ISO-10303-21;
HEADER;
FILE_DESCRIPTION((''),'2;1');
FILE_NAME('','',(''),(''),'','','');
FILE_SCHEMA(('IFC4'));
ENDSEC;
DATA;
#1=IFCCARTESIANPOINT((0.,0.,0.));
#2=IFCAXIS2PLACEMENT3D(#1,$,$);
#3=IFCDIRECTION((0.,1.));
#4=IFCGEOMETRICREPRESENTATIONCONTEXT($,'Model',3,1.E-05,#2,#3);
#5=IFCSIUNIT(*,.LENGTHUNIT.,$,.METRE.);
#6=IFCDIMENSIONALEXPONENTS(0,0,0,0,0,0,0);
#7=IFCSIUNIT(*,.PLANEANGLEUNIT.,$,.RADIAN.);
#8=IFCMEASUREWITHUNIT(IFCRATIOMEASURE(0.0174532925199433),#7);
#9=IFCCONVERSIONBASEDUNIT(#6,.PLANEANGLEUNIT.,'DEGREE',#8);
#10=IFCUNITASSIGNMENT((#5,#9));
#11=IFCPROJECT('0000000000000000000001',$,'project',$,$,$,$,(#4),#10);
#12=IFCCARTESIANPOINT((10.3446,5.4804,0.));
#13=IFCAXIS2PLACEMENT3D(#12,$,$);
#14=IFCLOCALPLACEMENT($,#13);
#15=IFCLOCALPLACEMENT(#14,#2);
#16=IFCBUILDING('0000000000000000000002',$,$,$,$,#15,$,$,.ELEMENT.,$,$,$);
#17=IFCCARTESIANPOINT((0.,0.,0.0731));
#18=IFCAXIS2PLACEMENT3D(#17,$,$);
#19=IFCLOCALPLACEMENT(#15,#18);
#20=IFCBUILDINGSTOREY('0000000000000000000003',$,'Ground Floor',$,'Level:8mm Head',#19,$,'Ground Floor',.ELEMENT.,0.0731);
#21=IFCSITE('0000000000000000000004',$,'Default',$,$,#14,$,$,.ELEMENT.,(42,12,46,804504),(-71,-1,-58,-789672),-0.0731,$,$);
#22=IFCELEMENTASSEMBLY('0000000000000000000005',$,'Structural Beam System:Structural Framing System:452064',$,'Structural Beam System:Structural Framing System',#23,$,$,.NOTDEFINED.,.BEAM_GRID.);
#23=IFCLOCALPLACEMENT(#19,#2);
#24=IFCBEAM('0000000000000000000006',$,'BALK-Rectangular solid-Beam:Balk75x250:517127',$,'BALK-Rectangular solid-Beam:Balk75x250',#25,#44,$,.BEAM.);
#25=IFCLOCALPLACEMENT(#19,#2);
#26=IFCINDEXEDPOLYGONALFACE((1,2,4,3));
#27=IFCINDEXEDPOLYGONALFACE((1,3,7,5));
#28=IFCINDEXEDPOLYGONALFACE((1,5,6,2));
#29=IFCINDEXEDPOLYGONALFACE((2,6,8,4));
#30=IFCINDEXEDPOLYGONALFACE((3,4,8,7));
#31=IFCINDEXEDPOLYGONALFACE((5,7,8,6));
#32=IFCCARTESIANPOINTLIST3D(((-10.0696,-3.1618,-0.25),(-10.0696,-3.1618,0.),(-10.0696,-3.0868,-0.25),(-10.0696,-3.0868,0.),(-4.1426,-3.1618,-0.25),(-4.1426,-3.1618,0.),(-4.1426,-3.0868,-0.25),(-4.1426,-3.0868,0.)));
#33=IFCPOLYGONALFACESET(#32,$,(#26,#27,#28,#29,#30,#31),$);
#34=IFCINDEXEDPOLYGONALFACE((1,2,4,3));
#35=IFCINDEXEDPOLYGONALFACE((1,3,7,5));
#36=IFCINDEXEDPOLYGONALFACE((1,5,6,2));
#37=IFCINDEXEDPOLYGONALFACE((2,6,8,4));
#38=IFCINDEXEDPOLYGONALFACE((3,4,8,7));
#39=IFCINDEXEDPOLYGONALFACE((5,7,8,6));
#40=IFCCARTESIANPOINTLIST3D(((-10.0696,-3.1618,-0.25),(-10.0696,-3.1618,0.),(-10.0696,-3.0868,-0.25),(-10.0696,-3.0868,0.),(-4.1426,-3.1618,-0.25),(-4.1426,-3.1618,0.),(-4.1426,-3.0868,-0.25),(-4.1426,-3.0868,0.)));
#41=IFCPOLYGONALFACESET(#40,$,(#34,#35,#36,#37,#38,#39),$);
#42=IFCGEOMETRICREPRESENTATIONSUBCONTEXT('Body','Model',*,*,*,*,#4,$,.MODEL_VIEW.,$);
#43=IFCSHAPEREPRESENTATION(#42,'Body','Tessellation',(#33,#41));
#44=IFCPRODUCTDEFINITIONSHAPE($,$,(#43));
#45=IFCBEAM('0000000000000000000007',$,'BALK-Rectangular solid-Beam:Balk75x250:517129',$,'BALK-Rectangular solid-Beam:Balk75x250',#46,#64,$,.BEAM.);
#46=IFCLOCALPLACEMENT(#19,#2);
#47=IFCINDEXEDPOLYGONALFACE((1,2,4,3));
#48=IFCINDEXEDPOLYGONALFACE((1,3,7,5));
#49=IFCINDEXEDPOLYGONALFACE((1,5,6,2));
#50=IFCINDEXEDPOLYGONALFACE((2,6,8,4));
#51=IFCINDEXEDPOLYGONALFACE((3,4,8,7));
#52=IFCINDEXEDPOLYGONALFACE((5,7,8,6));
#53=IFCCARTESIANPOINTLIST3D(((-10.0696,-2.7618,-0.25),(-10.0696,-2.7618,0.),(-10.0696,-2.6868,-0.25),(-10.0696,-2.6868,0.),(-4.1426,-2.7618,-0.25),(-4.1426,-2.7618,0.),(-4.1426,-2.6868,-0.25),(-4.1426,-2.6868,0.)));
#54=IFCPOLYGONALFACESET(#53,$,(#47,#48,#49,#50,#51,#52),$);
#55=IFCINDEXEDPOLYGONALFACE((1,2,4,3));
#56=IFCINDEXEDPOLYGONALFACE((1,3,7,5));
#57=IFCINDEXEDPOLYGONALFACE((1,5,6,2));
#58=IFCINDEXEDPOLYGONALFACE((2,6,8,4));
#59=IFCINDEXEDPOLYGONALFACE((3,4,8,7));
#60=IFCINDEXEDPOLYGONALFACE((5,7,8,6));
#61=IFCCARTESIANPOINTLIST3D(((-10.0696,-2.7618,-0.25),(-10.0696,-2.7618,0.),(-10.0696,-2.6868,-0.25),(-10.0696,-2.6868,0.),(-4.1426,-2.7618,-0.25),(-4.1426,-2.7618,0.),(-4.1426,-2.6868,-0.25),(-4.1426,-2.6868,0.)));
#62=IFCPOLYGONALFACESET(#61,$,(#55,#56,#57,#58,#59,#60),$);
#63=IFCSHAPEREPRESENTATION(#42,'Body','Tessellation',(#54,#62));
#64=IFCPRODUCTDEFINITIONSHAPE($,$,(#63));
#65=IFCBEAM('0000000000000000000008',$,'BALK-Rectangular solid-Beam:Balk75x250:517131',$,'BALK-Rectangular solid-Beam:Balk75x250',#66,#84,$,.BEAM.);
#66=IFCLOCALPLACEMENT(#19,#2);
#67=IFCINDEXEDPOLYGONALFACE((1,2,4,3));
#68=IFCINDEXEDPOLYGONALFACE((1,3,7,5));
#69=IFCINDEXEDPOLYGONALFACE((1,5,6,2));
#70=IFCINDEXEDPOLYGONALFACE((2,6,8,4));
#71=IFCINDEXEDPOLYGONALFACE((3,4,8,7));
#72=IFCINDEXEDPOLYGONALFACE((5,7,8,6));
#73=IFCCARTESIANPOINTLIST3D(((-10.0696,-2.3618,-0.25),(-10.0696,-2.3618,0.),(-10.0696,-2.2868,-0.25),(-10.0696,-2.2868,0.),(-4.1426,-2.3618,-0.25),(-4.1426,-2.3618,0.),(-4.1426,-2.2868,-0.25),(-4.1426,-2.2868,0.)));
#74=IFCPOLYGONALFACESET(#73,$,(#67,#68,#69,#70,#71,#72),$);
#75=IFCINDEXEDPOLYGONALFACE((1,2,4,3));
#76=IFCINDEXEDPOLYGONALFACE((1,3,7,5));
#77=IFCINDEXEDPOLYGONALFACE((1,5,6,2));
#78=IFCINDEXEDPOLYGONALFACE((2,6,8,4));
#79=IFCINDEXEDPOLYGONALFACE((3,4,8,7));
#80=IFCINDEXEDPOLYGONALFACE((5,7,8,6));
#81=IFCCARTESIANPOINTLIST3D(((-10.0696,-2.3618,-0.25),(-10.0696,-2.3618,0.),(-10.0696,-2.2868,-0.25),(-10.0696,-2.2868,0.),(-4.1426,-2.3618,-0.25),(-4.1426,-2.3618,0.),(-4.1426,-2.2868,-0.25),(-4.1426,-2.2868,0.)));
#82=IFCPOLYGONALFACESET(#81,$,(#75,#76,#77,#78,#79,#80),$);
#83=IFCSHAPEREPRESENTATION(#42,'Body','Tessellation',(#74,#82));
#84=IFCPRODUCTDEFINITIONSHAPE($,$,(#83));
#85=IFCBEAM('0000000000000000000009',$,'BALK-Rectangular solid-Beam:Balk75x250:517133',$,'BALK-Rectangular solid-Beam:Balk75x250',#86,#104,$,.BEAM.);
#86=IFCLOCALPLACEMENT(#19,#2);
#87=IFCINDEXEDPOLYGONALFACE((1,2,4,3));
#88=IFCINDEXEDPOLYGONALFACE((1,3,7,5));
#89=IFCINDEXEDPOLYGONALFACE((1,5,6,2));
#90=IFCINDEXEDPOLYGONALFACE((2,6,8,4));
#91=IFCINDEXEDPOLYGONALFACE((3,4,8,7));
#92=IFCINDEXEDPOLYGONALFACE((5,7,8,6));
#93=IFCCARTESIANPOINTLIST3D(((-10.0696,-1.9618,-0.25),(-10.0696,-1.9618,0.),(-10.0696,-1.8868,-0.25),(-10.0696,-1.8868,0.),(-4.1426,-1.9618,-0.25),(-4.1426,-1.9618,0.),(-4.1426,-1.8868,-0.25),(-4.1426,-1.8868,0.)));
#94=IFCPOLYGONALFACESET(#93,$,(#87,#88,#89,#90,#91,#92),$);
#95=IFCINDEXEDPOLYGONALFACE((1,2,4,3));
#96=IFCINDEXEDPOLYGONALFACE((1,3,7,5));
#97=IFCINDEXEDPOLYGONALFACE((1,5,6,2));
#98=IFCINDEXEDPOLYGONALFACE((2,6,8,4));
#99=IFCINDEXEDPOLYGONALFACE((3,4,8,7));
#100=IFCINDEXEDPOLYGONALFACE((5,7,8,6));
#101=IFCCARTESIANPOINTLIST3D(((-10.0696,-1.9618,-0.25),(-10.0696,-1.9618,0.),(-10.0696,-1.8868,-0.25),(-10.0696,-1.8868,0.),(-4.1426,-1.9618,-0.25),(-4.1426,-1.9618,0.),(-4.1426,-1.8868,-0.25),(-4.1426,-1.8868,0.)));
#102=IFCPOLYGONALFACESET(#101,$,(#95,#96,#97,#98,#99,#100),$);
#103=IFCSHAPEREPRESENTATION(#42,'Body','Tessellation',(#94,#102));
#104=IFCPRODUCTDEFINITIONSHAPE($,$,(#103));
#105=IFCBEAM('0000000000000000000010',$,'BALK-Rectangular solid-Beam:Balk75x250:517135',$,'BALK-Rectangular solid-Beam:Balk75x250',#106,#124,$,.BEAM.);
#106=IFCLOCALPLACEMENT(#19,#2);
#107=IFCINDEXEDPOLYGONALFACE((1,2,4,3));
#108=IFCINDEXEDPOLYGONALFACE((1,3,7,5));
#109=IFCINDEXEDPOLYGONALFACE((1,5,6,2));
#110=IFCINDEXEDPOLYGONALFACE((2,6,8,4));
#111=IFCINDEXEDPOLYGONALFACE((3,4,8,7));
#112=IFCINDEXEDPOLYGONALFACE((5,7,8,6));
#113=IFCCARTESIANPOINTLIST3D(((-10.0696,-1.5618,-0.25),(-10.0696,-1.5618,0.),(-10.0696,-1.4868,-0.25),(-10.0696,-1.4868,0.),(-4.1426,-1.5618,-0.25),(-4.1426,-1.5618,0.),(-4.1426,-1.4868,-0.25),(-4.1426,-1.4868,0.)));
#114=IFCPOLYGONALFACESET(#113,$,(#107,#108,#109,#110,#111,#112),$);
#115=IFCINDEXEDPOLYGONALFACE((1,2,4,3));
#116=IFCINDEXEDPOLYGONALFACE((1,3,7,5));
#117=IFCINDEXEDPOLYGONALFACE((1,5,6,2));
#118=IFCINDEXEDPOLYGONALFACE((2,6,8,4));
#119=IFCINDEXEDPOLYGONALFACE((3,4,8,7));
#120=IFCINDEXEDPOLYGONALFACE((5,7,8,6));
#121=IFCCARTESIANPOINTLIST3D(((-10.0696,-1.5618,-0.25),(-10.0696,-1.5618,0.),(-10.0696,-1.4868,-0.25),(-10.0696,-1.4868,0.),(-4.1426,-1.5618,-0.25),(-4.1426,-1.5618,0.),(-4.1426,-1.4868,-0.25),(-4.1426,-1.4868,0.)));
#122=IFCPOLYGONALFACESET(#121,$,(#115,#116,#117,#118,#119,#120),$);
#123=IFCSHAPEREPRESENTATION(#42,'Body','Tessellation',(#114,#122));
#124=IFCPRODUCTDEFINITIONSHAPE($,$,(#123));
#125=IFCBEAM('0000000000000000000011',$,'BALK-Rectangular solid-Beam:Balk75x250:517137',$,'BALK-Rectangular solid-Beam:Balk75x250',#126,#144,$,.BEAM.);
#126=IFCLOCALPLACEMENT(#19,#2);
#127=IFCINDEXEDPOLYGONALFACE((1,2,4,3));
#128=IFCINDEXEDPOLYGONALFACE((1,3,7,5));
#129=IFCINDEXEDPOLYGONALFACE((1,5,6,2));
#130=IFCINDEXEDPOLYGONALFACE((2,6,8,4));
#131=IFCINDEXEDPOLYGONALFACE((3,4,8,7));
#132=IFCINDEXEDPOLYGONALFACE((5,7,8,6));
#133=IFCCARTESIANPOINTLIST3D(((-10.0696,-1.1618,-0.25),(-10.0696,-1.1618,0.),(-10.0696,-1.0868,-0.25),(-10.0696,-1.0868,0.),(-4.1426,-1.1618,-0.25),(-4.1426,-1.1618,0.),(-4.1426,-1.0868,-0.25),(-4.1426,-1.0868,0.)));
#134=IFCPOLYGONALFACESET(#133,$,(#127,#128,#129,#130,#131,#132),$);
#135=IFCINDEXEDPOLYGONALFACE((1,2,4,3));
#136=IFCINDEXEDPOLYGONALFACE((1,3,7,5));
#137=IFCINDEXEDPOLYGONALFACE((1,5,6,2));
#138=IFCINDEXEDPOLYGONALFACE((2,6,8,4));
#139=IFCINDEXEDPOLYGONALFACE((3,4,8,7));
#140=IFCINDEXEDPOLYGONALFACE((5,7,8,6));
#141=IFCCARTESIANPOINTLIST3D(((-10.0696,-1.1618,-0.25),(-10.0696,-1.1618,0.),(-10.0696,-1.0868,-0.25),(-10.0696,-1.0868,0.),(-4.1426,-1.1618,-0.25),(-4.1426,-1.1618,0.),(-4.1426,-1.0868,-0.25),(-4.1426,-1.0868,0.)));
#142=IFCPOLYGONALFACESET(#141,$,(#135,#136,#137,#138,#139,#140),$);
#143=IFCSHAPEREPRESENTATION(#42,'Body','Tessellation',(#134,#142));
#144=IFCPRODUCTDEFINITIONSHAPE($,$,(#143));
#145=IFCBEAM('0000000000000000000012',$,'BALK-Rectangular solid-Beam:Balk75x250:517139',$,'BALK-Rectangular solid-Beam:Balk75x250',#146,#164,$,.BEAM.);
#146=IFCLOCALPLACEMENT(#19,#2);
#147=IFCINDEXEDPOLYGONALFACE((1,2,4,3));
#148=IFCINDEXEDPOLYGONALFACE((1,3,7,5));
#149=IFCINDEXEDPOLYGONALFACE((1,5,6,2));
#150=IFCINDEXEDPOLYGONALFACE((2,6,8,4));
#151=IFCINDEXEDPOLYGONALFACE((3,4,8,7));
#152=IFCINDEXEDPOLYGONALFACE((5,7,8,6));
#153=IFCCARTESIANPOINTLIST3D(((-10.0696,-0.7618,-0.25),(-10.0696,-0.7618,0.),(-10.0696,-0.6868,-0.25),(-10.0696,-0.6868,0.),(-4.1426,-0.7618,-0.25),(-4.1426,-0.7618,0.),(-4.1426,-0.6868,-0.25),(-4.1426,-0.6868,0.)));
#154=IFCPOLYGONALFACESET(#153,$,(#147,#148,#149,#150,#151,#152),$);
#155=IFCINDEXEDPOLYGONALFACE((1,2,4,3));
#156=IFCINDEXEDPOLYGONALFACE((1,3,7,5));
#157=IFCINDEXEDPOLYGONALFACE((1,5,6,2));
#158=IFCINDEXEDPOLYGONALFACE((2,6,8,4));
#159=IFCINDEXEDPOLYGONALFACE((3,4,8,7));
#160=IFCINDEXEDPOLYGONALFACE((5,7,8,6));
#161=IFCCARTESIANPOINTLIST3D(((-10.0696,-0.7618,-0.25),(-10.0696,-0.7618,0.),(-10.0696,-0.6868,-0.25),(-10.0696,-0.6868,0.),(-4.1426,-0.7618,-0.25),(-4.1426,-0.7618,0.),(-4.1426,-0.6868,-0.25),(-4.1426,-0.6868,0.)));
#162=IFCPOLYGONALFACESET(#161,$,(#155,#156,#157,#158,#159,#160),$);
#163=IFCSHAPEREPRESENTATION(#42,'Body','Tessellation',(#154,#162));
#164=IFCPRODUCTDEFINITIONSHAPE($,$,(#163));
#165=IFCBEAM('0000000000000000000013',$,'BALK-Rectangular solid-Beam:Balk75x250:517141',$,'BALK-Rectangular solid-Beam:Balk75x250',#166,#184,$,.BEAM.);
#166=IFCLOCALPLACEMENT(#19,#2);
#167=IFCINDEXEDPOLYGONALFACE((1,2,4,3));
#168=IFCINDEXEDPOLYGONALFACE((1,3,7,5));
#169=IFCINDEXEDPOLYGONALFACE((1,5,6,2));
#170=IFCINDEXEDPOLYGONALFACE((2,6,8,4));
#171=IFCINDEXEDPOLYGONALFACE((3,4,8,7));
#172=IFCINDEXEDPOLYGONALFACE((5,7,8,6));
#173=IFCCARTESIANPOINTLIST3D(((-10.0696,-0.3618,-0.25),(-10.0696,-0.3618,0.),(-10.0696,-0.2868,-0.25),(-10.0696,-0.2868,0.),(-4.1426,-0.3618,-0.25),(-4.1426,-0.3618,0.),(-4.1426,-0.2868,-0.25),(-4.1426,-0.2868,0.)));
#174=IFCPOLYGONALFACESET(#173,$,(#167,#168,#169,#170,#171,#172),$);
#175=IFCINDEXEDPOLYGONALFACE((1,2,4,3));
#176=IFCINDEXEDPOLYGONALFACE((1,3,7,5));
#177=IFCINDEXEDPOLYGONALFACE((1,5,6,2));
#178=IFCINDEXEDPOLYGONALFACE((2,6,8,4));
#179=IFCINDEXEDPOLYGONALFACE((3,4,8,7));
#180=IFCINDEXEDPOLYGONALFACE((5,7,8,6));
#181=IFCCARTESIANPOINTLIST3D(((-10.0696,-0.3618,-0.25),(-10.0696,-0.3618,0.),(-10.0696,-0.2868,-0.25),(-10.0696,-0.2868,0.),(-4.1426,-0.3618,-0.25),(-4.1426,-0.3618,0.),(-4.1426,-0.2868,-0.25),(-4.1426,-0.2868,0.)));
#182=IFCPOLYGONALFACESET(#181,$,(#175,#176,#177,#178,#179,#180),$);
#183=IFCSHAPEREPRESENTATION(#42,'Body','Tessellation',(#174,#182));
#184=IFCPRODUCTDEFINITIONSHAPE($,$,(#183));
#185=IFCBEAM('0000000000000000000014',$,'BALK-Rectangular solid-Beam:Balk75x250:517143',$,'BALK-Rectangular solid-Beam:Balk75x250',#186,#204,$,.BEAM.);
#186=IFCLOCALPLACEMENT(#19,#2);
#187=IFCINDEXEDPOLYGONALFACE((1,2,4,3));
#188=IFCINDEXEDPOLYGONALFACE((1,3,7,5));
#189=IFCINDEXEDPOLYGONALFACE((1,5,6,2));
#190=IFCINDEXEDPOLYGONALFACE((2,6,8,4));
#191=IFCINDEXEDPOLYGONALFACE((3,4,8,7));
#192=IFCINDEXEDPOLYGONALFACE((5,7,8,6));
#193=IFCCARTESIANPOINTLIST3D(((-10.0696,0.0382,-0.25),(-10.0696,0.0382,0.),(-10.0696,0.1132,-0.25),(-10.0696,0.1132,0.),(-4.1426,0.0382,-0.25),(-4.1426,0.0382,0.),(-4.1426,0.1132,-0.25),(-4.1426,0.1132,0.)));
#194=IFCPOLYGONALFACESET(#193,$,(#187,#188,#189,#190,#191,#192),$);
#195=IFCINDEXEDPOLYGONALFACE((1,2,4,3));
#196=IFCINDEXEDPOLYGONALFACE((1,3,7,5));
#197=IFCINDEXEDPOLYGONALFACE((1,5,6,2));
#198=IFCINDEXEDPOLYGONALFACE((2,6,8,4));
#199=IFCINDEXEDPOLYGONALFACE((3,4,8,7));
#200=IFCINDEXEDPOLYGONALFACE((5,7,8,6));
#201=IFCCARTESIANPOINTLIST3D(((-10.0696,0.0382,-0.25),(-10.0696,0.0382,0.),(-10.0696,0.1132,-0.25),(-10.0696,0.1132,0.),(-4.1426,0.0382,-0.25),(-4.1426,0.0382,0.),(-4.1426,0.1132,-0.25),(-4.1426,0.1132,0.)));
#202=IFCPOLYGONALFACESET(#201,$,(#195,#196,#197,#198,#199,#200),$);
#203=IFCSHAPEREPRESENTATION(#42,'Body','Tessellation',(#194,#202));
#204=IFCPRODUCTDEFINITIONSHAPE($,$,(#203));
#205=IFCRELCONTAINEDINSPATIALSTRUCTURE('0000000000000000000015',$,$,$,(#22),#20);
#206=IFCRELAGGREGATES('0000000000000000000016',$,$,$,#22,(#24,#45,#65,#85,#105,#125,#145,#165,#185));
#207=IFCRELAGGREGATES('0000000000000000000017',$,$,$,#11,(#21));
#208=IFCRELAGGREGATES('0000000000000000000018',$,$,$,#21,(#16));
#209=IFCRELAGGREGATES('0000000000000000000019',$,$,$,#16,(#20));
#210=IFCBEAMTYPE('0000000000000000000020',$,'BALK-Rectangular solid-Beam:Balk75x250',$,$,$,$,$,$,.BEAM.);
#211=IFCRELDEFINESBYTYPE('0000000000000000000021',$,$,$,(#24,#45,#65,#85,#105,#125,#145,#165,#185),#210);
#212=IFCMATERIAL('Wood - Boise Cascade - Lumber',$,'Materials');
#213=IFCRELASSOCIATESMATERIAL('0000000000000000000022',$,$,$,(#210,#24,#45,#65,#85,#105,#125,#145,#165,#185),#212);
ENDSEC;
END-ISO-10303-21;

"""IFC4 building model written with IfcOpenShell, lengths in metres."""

from ifc_helpers import new_model, entity, si_unit, converted_unit, direction, frame, frame_2d, origin, origin_2d_with_axis, place, context, subcontext, project, spatial, rectangle, extrude, source, transform, mapped, material, material_profile, profile_set, profile_usage, type_object, type_shapes, element, aggregate, save


model = new_model("IFC4")

# Units and contexts
model_context = context("Model", 3, precision=1e-05, world=origin(), true_north=direction((0.0, 1.0)))
body_context = subcontext(model_context, "Body", "Model", "MODEL_VIEW")
ifc_project = project(units=[si_unit("LENGTHUNIT", "METRE"), converted_unit("PLANEANGLEUNIT", "DEGREE", entity("IfcRatioMeasure", 0.0174532925199433), si_unit("PLANEANGLEUNIT", "RADIAN"), dimensions=[0, 0, 0, 0, 0, 0, 0])], contexts=[model_context])

# Site, building, storey
site_placement = place(None, frame((10.3446, 5.4804, 0.0)))
site = spatial("IfcSite", under=ifc_project, at=site_placement, Name="Default", CompositionType="ELEMENT", RefLatitude=(42, 12, 46, 804504), RefLongitude=(-71, -1, -58, -789672), RefElevation=-0.0731)
building_placement = place(site_placement, origin())
building = spatial("IfcBuilding", under=site, at=building_placement, CompositionType="ELEMENT")
storey_placement = place(building_placement, frame((0.0, 0.0, 0.0731)))
storey = spatial("IfcBuildingStorey", under=building, at=storey_placement, Name="Ground Floor", ObjectType="Level:8mm Head", LongName="Ground Floor", CompositionType="ELEMENT", Elevation=0.0731)

# Element assembly, beams
assembly_placement = place(storey_placement, origin())
assembly = element("IfcElementAssembly", 1, at=assembly_placement, inside=storey, Name="Structural Beam System:Structural Framing System:452064", ObjectType="Structural Beam System:Structural Framing System", AssemblyPlace="NOTDEFINED", PredefinedType="BEAM_GRID")
ifc_material_1 = material(Name="Wood - Boise Cascade - Lumber", Category="Materials")
ifc_material_profile = material_profile(ifc_material_1, rectangle(XDim=0.25, YDim=0.075, at=frame_2d((0.0, 0.0), x_axis=(1.0, 0.0))), Name="Balk75x250")
ifc_profile_set = profile_set([ifc_material_profile], Name="Balk75x250")
ifc_profile_usage_1 = profile_usage(ifc_profile_set, cardinal=8)
beam_type = type_object("IfcBeamType", Name="BALK-Rectangular solid-Beam:Balk75x250", PredefinedType="BEAM", material=ifc_profile_set)
shared_shape = source(origin(), body_context, "Body", "SweptSolid", [
    extrude(rectangle(XDim=0.25, YDim=0.075, at=origin_2d_with_axis()), frame((-2.9573, 0.0, 0.0), z_axis=(1.0, 0.0, 0.0), x_axis=(0.0, 0.0, -1.0)), (0.0, 0.0, 1.0), 5.927),
    extrude(rectangle(XDim=0.25, YDim=0.075, at=origin_2d_with_axis()), frame((-2.9573, 0.0, 0.0), z_axis=(1.0, 0.0, 0.0), x_axis=(0.0, 0.0, -1.0)), (0.0, 0.0, 1.0), 5.927),
])
type_shapes(beam_type, [shared_shape])
beam_1_placement = place(assembly_placement, frame((-7.0999, -3.1243, -0.125), z_axis=(0.0, 0.0, 1.0), x_axis=(-1.0, 0.0, 0.0)))
beam_1 = element("IfcBeam", 2, at=beam_1_placement, type_object=beam_type, material=ifc_profile_usage_1, Name="BALK-Rectangular solid-Beam:Balk75x250:517127", ObjectType="BALK-Rectangular solid-Beam:Balk75x250", PredefinedType="BEAM", context=body_context, shape_type="MappedRepresentation", body=[
    mapped(shared_shape, transform((0.0, 0.0, 0.0), scale=1.0)),
])
ifc_profile_usage_2 = profile_usage(ifc_profile_set, cardinal=8)
beam_2_placement = place(assembly_placement, frame((-7.0999, -2.7243, -0.125), z_axis=(0.0, 0.0, 1.0), x_axis=(-1.0, 0.0, 0.0)))
beam_2 = element("IfcBeam", 3, at=beam_2_placement, type_object=beam_type, material=ifc_profile_usage_2, Name="BALK-Rectangular solid-Beam:Balk75x250:517129", ObjectType="BALK-Rectangular solid-Beam:Balk75x250", PredefinedType="BEAM", context=body_context, shape_type="MappedRepresentation", body=[
    mapped(shared_shape, transform((0.0, 0.0, 0.0), scale=1.0)),
])
ifc_profile_usage_3 = profile_usage(ifc_profile_set, cardinal=8)
beam_3_placement = place(assembly_placement, frame((-7.0999, -2.3243, -0.125), z_axis=(0.0, 0.0, 1.0), x_axis=(-1.0, 0.0, 0.0)))
beam_3 = element("IfcBeam", 4, at=beam_3_placement, type_object=beam_type, material=ifc_profile_usage_3, Name="BALK-Rectangular solid-Beam:Balk75x250:517131", ObjectType="BALK-Rectangular solid-Beam:Balk75x250", PredefinedType="BEAM", context=body_context, shape_type="MappedRepresentation", body=[
    mapped(shared_shape, transform((0.0, 0.0, 0.0), scale=1.0)),
])
ifc_profile_usage_4 = profile_usage(ifc_profile_set, cardinal=8)
beam_4_placement = place(assembly_placement, frame((-7.0999, -1.9243, -0.125), z_axis=(0.0, 0.0, 1.0), x_axis=(-1.0, 0.0, 0.0)))
beam_4 = element("IfcBeam", 5, at=beam_4_placement, type_object=beam_type, material=ifc_profile_usage_4, Name="BALK-Rectangular solid-Beam:Balk75x250:517133", ObjectType="BALK-Rectangular solid-Beam:Balk75x250", PredefinedType="BEAM", context=body_context, shape_type="MappedRepresentation", body=[
    mapped(shared_shape, transform((0.0, 0.0, 0.0), scale=1.0)),
])
ifc_profile_usage_5 = profile_usage(ifc_profile_set, cardinal=8)
beam_5_placement = place(assembly_placement, frame((-7.0999, -1.5243, -0.125), z_axis=(0.0, 0.0, 1.0), x_axis=(-1.0, 0.0, 0.0)))
beam_5 = element("IfcBeam", 6, at=beam_5_placement, type_object=beam_type, material=ifc_profile_usage_5, Name="BALK-Rectangular solid-Beam:Balk75x250:517135", ObjectType="BALK-Rectangular solid-Beam:Balk75x250", PredefinedType="BEAM", context=body_context, shape_type="MappedRepresentation", body=[
    mapped(shared_shape, transform((0.0, 0.0, 0.0), scale=1.0)),
])
ifc_profile_usage_6 = profile_usage(ifc_profile_set, cardinal=8)
beam_6_placement = place(assembly_placement, frame((-7.0999, -1.1243, -0.125), z_axis=(0.0, 0.0, 1.0), x_axis=(-1.0, 0.0, 0.0)))
beam_6 = element("IfcBeam", 7, at=beam_6_placement, type_object=beam_type, material=ifc_profile_usage_6, Name="BALK-Rectangular solid-Beam:Balk75x250:517137", ObjectType="BALK-Rectangular solid-Beam:Balk75x250", PredefinedType="BEAM", context=body_context, shape_type="MappedRepresentation", body=[
    mapped(shared_shape, transform((0.0, 0.0, 0.0), scale=1.0)),
])
ifc_profile_usage_7 = profile_usage(ifc_profile_set, cardinal=8)
beam_7_placement = place(assembly_placement, frame((-7.0999, -0.7243, -0.125), z_axis=(0.0, 0.0, 1.0), x_axis=(-1.0, 0.0, 0.0)))
beam_7 = element("IfcBeam", 8, at=beam_7_placement, type_object=beam_type, material=ifc_profile_usage_7, Name="BALK-Rectangular solid-Beam:Balk75x250:517139", ObjectType="BALK-Rectangular solid-Beam:Balk75x250", PredefinedType="BEAM", context=body_context, shape_type="MappedRepresentation", body=[
    mapped(shared_shape, transform((0.0, 0.0, 0.0), scale=1.0)),
])
ifc_profile_usage_8 = profile_usage(ifc_profile_set, cardinal=8)
beam_8_placement = place(assembly_placement, frame((-7.0999, -0.3243, -0.125), z_axis=(0.0, 0.0, 1.0), x_axis=(-1.0, 0.0, 0.0)))
beam_8 = element("IfcBeam", 9, at=beam_8_placement, type_object=beam_type, material=ifc_profile_usage_8, Name="BALK-Rectangular solid-Beam:Balk75x250:517141", ObjectType="BALK-Rectangular solid-Beam:Balk75x250", PredefinedType="BEAM", context=body_context, shape_type="MappedRepresentation", body=[
    mapped(shared_shape, transform((0.0, 0.0, 0.0), scale=1.0)),
])
ifc_profile_usage_9 = profile_usage(ifc_profile_set, cardinal=8)
beam_9_placement = place(assembly_placement, frame((-7.0999, 0.0757, -0.125), z_axis=(0.0, 0.0, 1.0), x_axis=(-1.0, 0.0, 0.0)))
beam_9 = element("IfcBeam", 10, at=beam_9_placement, type_object=beam_type, material=ifc_profile_usage_9, Name="BALK-Rectangular solid-Beam:Balk75x250:517143", ObjectType="BALK-Rectangular solid-Beam:Balk75x250", PredefinedType="BEAM", context=body_context, shape_type="MappedRepresentation", body=[
    mapped(shared_shape, transform((0.0, 0.0, 0.0), scale=1.0)),
])
aggregate(assembly, [beam_1, beam_2, beam_3, beam_4, beam_5, beam_6, beam_7, beam_8, beam_9])

save(model, "model.ifc")
